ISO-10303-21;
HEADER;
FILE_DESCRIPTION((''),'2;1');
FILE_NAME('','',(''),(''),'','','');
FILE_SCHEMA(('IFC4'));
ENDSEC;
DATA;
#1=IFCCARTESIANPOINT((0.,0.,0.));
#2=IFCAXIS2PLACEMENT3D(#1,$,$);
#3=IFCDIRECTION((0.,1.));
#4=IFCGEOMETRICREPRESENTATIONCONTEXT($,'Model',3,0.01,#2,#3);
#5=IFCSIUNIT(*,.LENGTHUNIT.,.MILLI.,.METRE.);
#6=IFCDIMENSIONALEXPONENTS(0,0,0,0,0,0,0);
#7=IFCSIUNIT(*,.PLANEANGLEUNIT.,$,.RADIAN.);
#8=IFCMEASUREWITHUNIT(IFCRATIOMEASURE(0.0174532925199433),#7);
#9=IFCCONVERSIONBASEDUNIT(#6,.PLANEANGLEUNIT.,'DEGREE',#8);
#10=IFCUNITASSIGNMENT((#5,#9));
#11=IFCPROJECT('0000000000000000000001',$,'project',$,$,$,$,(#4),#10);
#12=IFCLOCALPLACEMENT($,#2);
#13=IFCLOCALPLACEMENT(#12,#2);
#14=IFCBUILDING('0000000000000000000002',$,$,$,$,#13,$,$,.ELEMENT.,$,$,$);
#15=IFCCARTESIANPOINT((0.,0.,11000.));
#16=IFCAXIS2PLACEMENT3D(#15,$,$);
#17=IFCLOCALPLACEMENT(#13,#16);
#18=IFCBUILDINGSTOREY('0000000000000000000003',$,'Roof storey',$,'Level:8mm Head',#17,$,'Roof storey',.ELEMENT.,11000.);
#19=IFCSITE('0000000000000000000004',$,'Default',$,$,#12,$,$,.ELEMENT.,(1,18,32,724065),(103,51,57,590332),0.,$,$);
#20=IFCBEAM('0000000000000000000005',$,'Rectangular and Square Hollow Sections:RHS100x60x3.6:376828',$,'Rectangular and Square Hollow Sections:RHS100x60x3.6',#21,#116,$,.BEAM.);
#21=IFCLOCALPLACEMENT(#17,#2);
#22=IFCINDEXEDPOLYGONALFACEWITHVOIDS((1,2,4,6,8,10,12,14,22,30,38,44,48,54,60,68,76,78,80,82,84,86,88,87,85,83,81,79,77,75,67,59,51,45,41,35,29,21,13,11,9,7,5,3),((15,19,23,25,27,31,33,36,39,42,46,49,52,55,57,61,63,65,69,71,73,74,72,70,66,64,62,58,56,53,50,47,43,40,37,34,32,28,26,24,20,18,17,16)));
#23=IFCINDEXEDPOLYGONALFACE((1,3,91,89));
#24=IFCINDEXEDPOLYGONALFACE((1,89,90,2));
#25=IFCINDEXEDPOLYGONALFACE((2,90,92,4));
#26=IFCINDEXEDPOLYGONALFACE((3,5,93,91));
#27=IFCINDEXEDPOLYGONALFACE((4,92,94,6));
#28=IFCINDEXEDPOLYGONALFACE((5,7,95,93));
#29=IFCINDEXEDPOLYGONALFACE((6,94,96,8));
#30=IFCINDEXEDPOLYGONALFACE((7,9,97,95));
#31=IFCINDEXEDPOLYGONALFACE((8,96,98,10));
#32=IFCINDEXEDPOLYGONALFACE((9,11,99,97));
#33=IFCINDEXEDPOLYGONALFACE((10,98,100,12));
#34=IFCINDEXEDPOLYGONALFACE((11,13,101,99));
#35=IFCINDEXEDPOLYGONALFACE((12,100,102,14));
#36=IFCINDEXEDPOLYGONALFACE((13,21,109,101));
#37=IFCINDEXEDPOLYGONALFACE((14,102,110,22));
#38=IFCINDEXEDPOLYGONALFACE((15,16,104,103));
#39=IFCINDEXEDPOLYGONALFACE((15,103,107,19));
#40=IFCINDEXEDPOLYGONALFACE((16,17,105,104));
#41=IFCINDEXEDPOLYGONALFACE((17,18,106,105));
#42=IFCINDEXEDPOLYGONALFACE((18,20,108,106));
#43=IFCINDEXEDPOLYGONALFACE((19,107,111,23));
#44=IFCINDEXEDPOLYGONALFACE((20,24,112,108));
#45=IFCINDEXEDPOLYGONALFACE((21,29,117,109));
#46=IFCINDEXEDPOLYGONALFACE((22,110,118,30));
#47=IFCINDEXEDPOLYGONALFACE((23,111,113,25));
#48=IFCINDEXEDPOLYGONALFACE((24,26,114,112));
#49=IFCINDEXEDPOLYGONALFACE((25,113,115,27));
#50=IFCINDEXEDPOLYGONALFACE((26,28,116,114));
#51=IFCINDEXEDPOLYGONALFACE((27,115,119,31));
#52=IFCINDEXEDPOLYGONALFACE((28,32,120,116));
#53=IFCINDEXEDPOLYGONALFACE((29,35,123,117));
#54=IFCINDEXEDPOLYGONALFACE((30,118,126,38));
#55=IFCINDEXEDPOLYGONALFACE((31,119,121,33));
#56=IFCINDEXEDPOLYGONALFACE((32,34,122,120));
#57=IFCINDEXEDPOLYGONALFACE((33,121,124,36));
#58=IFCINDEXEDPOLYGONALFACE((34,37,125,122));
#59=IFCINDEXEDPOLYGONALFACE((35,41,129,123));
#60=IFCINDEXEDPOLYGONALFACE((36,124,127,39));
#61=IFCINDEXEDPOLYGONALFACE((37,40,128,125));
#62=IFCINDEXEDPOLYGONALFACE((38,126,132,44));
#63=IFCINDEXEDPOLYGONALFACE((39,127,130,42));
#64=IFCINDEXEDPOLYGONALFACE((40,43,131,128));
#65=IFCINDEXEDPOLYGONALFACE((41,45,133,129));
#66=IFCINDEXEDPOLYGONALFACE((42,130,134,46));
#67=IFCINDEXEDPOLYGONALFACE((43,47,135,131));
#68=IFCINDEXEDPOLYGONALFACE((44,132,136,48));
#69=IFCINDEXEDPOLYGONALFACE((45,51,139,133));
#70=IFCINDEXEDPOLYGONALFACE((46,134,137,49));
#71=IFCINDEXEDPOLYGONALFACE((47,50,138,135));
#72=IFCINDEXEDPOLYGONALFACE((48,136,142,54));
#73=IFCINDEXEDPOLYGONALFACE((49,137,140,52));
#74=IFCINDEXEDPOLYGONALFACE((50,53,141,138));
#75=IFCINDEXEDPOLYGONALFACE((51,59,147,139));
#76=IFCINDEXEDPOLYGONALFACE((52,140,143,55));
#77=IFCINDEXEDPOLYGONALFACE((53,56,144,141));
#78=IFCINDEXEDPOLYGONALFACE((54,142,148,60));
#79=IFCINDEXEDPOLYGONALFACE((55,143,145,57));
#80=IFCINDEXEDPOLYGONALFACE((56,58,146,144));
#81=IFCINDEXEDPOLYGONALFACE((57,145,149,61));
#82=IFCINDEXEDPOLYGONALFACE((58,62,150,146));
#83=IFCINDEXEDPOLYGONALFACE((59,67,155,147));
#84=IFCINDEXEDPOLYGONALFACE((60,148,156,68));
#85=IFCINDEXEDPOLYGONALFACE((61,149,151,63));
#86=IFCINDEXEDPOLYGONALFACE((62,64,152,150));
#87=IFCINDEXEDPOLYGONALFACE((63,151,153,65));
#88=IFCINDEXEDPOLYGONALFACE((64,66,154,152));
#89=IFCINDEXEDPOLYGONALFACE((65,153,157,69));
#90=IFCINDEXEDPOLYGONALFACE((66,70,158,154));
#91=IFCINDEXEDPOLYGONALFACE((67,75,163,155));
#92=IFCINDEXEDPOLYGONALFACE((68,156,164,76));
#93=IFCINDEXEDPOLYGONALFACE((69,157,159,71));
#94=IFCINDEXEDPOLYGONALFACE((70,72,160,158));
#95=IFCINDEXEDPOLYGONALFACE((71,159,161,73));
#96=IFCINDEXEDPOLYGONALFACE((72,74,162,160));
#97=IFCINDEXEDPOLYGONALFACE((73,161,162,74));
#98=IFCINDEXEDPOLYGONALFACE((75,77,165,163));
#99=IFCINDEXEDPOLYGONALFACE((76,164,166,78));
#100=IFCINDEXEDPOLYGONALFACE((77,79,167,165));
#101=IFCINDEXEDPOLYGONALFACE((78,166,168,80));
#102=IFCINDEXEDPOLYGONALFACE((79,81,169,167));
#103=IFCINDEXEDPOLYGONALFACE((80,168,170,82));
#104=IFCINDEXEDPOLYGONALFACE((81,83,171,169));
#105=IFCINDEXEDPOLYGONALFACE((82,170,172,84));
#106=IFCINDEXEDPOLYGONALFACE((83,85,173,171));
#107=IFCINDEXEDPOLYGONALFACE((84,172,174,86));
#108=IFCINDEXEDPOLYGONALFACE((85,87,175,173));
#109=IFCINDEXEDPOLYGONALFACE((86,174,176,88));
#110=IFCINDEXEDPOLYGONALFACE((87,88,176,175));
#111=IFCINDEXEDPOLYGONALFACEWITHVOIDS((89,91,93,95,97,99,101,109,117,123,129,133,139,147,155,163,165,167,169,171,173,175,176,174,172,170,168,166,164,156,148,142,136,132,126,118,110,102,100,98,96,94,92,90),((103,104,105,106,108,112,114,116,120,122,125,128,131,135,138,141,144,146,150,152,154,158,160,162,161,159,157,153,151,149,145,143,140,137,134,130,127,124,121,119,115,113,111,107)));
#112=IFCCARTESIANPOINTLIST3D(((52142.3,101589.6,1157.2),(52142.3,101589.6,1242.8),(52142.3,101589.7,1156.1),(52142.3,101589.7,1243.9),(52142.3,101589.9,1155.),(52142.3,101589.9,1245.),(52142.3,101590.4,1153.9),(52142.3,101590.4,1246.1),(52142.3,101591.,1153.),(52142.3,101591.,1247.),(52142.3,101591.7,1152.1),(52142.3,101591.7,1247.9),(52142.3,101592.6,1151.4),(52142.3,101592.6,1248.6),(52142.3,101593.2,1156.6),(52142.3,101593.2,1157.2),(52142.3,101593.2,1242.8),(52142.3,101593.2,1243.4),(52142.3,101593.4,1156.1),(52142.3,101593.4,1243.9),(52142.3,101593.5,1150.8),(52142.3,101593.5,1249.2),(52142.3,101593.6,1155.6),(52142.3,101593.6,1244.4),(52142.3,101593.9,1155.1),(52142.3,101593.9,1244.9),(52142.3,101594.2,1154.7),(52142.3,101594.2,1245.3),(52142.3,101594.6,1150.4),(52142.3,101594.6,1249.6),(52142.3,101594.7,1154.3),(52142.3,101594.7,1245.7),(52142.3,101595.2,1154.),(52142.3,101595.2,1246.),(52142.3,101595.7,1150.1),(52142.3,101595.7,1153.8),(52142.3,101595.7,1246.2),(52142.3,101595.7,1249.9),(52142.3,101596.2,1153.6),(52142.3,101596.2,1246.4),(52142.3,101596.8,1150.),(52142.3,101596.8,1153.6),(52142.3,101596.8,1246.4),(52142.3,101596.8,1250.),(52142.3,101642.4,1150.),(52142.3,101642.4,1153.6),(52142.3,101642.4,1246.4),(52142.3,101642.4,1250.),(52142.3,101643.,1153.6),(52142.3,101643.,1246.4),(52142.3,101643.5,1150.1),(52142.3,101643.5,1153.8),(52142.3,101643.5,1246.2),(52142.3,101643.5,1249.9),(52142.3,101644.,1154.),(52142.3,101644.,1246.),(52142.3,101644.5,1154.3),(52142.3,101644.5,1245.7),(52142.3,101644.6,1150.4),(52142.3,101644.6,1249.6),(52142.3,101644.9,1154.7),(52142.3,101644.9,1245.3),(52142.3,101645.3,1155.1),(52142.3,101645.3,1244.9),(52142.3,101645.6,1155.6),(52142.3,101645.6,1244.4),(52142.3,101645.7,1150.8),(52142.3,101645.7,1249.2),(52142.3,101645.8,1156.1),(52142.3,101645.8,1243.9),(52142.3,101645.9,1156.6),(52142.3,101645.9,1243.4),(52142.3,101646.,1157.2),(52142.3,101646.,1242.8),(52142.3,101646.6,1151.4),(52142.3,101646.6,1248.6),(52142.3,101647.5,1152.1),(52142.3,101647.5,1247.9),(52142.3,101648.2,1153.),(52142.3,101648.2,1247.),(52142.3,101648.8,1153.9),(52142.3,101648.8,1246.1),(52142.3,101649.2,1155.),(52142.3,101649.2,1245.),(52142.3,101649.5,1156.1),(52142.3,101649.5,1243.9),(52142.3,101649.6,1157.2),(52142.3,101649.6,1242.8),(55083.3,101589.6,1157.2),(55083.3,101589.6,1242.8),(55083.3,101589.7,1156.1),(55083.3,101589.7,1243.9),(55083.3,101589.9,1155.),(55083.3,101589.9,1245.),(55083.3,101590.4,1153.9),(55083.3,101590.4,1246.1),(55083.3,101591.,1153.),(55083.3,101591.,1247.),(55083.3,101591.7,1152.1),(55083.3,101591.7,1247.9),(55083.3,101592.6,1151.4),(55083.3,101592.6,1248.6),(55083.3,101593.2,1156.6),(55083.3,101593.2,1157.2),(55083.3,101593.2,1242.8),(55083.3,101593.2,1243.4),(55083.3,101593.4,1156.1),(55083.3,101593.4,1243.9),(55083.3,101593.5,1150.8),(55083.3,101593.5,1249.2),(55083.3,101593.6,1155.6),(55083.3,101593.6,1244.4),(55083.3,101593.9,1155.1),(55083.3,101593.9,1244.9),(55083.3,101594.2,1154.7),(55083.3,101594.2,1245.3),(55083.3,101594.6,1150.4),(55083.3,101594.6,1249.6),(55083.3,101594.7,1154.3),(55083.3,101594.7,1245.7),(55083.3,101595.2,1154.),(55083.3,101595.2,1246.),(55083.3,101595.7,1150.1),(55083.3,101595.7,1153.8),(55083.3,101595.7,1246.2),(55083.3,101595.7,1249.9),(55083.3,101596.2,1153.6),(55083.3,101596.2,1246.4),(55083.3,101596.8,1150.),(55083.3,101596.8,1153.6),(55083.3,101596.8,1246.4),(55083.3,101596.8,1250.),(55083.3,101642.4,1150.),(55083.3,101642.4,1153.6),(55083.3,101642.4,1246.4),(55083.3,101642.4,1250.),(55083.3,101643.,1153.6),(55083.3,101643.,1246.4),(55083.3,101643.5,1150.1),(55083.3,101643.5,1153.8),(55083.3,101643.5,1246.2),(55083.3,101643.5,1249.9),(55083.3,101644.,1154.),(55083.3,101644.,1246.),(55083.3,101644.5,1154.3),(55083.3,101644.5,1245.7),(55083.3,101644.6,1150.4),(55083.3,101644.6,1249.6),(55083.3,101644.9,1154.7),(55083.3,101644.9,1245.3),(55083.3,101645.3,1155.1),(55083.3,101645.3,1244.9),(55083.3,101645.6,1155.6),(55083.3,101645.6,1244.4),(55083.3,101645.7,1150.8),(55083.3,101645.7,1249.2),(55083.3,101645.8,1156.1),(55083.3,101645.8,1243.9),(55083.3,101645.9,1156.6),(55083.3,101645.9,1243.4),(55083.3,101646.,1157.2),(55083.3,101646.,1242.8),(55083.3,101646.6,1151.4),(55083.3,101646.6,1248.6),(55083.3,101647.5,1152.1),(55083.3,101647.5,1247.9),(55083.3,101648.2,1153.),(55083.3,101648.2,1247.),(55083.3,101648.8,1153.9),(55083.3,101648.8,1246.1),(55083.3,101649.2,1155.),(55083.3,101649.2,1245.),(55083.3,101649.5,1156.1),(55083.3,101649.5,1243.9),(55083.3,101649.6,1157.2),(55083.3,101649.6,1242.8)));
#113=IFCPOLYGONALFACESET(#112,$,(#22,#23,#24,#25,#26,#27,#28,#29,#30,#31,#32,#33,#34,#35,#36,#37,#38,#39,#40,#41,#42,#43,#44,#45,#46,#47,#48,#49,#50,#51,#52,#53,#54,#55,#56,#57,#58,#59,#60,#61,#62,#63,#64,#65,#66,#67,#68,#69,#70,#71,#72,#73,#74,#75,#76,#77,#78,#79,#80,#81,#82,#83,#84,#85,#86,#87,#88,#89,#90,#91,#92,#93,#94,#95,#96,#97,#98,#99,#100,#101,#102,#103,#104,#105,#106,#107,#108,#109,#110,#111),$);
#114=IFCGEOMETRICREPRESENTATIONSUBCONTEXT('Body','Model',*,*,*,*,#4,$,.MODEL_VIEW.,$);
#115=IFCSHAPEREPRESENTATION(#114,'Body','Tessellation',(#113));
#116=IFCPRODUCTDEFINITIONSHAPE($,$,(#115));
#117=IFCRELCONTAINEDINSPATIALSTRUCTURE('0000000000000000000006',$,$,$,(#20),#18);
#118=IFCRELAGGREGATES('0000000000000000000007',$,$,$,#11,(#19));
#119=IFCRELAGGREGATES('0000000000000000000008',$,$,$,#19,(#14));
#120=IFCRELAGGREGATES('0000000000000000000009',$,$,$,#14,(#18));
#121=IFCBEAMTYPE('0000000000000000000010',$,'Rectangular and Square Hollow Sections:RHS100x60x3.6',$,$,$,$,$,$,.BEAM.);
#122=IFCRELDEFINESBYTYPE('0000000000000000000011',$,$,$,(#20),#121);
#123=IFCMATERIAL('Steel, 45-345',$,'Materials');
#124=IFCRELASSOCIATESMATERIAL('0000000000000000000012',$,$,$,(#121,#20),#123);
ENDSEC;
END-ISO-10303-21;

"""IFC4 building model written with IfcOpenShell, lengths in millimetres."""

from ifc_helpers import new_model, entity, si_unit, converted_unit, direction, frame, origin, place, context, subcontext, project, spatial, indexed_curve, outline, extrude, source, transform, mapped, material, type_object, type_shapes, element, save


model = new_model("IFC4")

# Units and contexts
model_context = context("Model", 3, precision=0.01, world=origin(), true_north=direction((0.0, 1.0)))
body_context = subcontext(model_context, "Body", "Model", "MODEL_VIEW")
ifc_project = project(units=[si_unit("LENGTHUNIT", "METRE", prefix="MILLI"), converted_unit("PLANEANGLEUNIT", "DEGREE", entity("IfcRatioMeasure", 0.0174532925199433), si_unit("PLANEANGLEUNIT", "RADIAN"), dimensions=[0, 0, 0, 0, 0, 0, 0])], contexts=[model_context])

# Site, building, storey
site_placement = place(None, origin())
site = spatial("IfcSite", under=ifc_project, at=site_placement, Name="Default", CompositionType="ELEMENT", RefLatitude=(1, 18, 32, 724065), RefLongitude=(103, 51, 57, 590332), RefElevation=0.0)
building_placement = place(site_placement, origin())
building = spatial("IfcBuilding", under=site, at=building_placement, CompositionType="ELEMENT")
storey_placement = place(building_placement, frame((0.0, 0.0, 11000.0)))
storey = spatial("IfcBuildingStorey", under=building, at=storey_placement, Name="Roof storey", ObjectType="Level:8mm Head", LongName="Roof storey", CompositionType="ELEMENT", Elevation=11000.0)

# Shared definitions
ifc_material = material(Name="Steel, 45-345", Category="Materials")

# Beam
beam_type_1 = type_object("IfcBeamType", Name="Rectangular and Square Hollow Sections:RHS100x60x3.6", PredefinedType="BEAM", material=ifc_material)
shared_shape_1 = source(origin(), body_context, "Body", "SweptSolid", [
    extrude(outline(indexed_curve([(-30.0, -42.8), (-29.9, -43.9), (-29.6, -45.0), (-29.2, -46.1), (-28.6, -47.0), (-27.9, -47.9), (-27.0, -48.6), (-26.1, -49.2), (-25.0, -49.6), (-23.9, -49.9), (-22.8, -50.0), (22.8, -50.0), (23.9, -49.9), (25.0, -49.6), (26.1, -49.2), (27.0, -48.6), (27.9, -47.9), (28.6, -47.0), (29.2, -46.1), (29.6, -45.0), (29.9, -43.9), (30.0, -42.8), (30.0, 42.8), (29.9, 43.9), (29.6, 45.0), (29.2, 46.1), (28.6, 47.0), (27.9, 47.9), (27.0, 48.6), (26.1, 49.2), (25.0, 49.6), (23.9, 49.9), (22.8, 50.0), (-22.8, 50.0), (-23.9, 49.9), (-25.0, 49.6), (-26.1, 49.2), (-27.0, 48.6), (-27.9, 47.9), (-28.6, 47.0), (-29.2, 46.1), (-29.6, 45.0), (-29.9, 43.9), (-30.0, 42.8), (-30.0, -42.8)], self_intersect=False), holes=[indexed_curve([(22.8, -46.4), (-22.8, -46.4), (-23.4, -46.4), (-23.9, -46.2), (-24.4, -46.0), (-24.9, -45.7), (-25.3, -45.3), (-25.7, -44.9), (-26.0, -44.4), (-26.2, -43.9), (-26.4, -43.4), (-26.4, -42.8), (-26.4, 42.8), (-26.4, 43.4), (-26.2, 43.9), (-26.0, 44.4), (-25.7, 44.9), (-25.3, 45.3), (-24.9, 45.7), (-24.4, 46.0), (-23.9, 46.2), (-23.4, 46.4), (-22.8, 46.4), (22.8, 46.4), (23.4, 46.4), (23.9, 46.2), (24.4, 46.0), (24.9, 45.7), (25.3, 45.3), (25.7, 44.9), (26.0, 44.4), (26.2, 43.9), (26.4, 43.4), (26.4, 42.8), (26.4, -42.8), (26.4, -43.4), (26.2, -43.9), (26.0, -44.4), (25.7, -44.9), (25.3, -45.3), (24.9, -45.7), (24.4, -46.0), (23.9, -46.2), (23.4, -46.4), (22.8, -46.4)], self_intersect=False)]), frame((-1477.0, 0.0, 0.0), z_axis=(1.0, 0.0, 0.0), x_axis=(0.0, -1.0, 0.0)), (0.0, 0.0, 1.0), 2941.0),
])
type_shapes(beam_type_1, [shared_shape_1])
beam_1_placement = place(storey_placement, frame((53619.3, 101619.6, 1200.0)))
element("IfcBeam", 1, at=beam_1_placement, inside=storey, type_object=beam_type_1, material=ifc_material, Name="Rectangular and Square Hollow Sections:RHS100x60x3.6:376828", ObjectType="Rectangular and Square Hollow Sections:RHS100x60x3.6", PredefinedType="BEAM", context=body_context, shape_type="MappedRepresentation", body=[
    mapped(shared_shape_1, transform((0.0, 0.0, 0.0), scale=1.0)),
])

save(model, "model.ifc")
